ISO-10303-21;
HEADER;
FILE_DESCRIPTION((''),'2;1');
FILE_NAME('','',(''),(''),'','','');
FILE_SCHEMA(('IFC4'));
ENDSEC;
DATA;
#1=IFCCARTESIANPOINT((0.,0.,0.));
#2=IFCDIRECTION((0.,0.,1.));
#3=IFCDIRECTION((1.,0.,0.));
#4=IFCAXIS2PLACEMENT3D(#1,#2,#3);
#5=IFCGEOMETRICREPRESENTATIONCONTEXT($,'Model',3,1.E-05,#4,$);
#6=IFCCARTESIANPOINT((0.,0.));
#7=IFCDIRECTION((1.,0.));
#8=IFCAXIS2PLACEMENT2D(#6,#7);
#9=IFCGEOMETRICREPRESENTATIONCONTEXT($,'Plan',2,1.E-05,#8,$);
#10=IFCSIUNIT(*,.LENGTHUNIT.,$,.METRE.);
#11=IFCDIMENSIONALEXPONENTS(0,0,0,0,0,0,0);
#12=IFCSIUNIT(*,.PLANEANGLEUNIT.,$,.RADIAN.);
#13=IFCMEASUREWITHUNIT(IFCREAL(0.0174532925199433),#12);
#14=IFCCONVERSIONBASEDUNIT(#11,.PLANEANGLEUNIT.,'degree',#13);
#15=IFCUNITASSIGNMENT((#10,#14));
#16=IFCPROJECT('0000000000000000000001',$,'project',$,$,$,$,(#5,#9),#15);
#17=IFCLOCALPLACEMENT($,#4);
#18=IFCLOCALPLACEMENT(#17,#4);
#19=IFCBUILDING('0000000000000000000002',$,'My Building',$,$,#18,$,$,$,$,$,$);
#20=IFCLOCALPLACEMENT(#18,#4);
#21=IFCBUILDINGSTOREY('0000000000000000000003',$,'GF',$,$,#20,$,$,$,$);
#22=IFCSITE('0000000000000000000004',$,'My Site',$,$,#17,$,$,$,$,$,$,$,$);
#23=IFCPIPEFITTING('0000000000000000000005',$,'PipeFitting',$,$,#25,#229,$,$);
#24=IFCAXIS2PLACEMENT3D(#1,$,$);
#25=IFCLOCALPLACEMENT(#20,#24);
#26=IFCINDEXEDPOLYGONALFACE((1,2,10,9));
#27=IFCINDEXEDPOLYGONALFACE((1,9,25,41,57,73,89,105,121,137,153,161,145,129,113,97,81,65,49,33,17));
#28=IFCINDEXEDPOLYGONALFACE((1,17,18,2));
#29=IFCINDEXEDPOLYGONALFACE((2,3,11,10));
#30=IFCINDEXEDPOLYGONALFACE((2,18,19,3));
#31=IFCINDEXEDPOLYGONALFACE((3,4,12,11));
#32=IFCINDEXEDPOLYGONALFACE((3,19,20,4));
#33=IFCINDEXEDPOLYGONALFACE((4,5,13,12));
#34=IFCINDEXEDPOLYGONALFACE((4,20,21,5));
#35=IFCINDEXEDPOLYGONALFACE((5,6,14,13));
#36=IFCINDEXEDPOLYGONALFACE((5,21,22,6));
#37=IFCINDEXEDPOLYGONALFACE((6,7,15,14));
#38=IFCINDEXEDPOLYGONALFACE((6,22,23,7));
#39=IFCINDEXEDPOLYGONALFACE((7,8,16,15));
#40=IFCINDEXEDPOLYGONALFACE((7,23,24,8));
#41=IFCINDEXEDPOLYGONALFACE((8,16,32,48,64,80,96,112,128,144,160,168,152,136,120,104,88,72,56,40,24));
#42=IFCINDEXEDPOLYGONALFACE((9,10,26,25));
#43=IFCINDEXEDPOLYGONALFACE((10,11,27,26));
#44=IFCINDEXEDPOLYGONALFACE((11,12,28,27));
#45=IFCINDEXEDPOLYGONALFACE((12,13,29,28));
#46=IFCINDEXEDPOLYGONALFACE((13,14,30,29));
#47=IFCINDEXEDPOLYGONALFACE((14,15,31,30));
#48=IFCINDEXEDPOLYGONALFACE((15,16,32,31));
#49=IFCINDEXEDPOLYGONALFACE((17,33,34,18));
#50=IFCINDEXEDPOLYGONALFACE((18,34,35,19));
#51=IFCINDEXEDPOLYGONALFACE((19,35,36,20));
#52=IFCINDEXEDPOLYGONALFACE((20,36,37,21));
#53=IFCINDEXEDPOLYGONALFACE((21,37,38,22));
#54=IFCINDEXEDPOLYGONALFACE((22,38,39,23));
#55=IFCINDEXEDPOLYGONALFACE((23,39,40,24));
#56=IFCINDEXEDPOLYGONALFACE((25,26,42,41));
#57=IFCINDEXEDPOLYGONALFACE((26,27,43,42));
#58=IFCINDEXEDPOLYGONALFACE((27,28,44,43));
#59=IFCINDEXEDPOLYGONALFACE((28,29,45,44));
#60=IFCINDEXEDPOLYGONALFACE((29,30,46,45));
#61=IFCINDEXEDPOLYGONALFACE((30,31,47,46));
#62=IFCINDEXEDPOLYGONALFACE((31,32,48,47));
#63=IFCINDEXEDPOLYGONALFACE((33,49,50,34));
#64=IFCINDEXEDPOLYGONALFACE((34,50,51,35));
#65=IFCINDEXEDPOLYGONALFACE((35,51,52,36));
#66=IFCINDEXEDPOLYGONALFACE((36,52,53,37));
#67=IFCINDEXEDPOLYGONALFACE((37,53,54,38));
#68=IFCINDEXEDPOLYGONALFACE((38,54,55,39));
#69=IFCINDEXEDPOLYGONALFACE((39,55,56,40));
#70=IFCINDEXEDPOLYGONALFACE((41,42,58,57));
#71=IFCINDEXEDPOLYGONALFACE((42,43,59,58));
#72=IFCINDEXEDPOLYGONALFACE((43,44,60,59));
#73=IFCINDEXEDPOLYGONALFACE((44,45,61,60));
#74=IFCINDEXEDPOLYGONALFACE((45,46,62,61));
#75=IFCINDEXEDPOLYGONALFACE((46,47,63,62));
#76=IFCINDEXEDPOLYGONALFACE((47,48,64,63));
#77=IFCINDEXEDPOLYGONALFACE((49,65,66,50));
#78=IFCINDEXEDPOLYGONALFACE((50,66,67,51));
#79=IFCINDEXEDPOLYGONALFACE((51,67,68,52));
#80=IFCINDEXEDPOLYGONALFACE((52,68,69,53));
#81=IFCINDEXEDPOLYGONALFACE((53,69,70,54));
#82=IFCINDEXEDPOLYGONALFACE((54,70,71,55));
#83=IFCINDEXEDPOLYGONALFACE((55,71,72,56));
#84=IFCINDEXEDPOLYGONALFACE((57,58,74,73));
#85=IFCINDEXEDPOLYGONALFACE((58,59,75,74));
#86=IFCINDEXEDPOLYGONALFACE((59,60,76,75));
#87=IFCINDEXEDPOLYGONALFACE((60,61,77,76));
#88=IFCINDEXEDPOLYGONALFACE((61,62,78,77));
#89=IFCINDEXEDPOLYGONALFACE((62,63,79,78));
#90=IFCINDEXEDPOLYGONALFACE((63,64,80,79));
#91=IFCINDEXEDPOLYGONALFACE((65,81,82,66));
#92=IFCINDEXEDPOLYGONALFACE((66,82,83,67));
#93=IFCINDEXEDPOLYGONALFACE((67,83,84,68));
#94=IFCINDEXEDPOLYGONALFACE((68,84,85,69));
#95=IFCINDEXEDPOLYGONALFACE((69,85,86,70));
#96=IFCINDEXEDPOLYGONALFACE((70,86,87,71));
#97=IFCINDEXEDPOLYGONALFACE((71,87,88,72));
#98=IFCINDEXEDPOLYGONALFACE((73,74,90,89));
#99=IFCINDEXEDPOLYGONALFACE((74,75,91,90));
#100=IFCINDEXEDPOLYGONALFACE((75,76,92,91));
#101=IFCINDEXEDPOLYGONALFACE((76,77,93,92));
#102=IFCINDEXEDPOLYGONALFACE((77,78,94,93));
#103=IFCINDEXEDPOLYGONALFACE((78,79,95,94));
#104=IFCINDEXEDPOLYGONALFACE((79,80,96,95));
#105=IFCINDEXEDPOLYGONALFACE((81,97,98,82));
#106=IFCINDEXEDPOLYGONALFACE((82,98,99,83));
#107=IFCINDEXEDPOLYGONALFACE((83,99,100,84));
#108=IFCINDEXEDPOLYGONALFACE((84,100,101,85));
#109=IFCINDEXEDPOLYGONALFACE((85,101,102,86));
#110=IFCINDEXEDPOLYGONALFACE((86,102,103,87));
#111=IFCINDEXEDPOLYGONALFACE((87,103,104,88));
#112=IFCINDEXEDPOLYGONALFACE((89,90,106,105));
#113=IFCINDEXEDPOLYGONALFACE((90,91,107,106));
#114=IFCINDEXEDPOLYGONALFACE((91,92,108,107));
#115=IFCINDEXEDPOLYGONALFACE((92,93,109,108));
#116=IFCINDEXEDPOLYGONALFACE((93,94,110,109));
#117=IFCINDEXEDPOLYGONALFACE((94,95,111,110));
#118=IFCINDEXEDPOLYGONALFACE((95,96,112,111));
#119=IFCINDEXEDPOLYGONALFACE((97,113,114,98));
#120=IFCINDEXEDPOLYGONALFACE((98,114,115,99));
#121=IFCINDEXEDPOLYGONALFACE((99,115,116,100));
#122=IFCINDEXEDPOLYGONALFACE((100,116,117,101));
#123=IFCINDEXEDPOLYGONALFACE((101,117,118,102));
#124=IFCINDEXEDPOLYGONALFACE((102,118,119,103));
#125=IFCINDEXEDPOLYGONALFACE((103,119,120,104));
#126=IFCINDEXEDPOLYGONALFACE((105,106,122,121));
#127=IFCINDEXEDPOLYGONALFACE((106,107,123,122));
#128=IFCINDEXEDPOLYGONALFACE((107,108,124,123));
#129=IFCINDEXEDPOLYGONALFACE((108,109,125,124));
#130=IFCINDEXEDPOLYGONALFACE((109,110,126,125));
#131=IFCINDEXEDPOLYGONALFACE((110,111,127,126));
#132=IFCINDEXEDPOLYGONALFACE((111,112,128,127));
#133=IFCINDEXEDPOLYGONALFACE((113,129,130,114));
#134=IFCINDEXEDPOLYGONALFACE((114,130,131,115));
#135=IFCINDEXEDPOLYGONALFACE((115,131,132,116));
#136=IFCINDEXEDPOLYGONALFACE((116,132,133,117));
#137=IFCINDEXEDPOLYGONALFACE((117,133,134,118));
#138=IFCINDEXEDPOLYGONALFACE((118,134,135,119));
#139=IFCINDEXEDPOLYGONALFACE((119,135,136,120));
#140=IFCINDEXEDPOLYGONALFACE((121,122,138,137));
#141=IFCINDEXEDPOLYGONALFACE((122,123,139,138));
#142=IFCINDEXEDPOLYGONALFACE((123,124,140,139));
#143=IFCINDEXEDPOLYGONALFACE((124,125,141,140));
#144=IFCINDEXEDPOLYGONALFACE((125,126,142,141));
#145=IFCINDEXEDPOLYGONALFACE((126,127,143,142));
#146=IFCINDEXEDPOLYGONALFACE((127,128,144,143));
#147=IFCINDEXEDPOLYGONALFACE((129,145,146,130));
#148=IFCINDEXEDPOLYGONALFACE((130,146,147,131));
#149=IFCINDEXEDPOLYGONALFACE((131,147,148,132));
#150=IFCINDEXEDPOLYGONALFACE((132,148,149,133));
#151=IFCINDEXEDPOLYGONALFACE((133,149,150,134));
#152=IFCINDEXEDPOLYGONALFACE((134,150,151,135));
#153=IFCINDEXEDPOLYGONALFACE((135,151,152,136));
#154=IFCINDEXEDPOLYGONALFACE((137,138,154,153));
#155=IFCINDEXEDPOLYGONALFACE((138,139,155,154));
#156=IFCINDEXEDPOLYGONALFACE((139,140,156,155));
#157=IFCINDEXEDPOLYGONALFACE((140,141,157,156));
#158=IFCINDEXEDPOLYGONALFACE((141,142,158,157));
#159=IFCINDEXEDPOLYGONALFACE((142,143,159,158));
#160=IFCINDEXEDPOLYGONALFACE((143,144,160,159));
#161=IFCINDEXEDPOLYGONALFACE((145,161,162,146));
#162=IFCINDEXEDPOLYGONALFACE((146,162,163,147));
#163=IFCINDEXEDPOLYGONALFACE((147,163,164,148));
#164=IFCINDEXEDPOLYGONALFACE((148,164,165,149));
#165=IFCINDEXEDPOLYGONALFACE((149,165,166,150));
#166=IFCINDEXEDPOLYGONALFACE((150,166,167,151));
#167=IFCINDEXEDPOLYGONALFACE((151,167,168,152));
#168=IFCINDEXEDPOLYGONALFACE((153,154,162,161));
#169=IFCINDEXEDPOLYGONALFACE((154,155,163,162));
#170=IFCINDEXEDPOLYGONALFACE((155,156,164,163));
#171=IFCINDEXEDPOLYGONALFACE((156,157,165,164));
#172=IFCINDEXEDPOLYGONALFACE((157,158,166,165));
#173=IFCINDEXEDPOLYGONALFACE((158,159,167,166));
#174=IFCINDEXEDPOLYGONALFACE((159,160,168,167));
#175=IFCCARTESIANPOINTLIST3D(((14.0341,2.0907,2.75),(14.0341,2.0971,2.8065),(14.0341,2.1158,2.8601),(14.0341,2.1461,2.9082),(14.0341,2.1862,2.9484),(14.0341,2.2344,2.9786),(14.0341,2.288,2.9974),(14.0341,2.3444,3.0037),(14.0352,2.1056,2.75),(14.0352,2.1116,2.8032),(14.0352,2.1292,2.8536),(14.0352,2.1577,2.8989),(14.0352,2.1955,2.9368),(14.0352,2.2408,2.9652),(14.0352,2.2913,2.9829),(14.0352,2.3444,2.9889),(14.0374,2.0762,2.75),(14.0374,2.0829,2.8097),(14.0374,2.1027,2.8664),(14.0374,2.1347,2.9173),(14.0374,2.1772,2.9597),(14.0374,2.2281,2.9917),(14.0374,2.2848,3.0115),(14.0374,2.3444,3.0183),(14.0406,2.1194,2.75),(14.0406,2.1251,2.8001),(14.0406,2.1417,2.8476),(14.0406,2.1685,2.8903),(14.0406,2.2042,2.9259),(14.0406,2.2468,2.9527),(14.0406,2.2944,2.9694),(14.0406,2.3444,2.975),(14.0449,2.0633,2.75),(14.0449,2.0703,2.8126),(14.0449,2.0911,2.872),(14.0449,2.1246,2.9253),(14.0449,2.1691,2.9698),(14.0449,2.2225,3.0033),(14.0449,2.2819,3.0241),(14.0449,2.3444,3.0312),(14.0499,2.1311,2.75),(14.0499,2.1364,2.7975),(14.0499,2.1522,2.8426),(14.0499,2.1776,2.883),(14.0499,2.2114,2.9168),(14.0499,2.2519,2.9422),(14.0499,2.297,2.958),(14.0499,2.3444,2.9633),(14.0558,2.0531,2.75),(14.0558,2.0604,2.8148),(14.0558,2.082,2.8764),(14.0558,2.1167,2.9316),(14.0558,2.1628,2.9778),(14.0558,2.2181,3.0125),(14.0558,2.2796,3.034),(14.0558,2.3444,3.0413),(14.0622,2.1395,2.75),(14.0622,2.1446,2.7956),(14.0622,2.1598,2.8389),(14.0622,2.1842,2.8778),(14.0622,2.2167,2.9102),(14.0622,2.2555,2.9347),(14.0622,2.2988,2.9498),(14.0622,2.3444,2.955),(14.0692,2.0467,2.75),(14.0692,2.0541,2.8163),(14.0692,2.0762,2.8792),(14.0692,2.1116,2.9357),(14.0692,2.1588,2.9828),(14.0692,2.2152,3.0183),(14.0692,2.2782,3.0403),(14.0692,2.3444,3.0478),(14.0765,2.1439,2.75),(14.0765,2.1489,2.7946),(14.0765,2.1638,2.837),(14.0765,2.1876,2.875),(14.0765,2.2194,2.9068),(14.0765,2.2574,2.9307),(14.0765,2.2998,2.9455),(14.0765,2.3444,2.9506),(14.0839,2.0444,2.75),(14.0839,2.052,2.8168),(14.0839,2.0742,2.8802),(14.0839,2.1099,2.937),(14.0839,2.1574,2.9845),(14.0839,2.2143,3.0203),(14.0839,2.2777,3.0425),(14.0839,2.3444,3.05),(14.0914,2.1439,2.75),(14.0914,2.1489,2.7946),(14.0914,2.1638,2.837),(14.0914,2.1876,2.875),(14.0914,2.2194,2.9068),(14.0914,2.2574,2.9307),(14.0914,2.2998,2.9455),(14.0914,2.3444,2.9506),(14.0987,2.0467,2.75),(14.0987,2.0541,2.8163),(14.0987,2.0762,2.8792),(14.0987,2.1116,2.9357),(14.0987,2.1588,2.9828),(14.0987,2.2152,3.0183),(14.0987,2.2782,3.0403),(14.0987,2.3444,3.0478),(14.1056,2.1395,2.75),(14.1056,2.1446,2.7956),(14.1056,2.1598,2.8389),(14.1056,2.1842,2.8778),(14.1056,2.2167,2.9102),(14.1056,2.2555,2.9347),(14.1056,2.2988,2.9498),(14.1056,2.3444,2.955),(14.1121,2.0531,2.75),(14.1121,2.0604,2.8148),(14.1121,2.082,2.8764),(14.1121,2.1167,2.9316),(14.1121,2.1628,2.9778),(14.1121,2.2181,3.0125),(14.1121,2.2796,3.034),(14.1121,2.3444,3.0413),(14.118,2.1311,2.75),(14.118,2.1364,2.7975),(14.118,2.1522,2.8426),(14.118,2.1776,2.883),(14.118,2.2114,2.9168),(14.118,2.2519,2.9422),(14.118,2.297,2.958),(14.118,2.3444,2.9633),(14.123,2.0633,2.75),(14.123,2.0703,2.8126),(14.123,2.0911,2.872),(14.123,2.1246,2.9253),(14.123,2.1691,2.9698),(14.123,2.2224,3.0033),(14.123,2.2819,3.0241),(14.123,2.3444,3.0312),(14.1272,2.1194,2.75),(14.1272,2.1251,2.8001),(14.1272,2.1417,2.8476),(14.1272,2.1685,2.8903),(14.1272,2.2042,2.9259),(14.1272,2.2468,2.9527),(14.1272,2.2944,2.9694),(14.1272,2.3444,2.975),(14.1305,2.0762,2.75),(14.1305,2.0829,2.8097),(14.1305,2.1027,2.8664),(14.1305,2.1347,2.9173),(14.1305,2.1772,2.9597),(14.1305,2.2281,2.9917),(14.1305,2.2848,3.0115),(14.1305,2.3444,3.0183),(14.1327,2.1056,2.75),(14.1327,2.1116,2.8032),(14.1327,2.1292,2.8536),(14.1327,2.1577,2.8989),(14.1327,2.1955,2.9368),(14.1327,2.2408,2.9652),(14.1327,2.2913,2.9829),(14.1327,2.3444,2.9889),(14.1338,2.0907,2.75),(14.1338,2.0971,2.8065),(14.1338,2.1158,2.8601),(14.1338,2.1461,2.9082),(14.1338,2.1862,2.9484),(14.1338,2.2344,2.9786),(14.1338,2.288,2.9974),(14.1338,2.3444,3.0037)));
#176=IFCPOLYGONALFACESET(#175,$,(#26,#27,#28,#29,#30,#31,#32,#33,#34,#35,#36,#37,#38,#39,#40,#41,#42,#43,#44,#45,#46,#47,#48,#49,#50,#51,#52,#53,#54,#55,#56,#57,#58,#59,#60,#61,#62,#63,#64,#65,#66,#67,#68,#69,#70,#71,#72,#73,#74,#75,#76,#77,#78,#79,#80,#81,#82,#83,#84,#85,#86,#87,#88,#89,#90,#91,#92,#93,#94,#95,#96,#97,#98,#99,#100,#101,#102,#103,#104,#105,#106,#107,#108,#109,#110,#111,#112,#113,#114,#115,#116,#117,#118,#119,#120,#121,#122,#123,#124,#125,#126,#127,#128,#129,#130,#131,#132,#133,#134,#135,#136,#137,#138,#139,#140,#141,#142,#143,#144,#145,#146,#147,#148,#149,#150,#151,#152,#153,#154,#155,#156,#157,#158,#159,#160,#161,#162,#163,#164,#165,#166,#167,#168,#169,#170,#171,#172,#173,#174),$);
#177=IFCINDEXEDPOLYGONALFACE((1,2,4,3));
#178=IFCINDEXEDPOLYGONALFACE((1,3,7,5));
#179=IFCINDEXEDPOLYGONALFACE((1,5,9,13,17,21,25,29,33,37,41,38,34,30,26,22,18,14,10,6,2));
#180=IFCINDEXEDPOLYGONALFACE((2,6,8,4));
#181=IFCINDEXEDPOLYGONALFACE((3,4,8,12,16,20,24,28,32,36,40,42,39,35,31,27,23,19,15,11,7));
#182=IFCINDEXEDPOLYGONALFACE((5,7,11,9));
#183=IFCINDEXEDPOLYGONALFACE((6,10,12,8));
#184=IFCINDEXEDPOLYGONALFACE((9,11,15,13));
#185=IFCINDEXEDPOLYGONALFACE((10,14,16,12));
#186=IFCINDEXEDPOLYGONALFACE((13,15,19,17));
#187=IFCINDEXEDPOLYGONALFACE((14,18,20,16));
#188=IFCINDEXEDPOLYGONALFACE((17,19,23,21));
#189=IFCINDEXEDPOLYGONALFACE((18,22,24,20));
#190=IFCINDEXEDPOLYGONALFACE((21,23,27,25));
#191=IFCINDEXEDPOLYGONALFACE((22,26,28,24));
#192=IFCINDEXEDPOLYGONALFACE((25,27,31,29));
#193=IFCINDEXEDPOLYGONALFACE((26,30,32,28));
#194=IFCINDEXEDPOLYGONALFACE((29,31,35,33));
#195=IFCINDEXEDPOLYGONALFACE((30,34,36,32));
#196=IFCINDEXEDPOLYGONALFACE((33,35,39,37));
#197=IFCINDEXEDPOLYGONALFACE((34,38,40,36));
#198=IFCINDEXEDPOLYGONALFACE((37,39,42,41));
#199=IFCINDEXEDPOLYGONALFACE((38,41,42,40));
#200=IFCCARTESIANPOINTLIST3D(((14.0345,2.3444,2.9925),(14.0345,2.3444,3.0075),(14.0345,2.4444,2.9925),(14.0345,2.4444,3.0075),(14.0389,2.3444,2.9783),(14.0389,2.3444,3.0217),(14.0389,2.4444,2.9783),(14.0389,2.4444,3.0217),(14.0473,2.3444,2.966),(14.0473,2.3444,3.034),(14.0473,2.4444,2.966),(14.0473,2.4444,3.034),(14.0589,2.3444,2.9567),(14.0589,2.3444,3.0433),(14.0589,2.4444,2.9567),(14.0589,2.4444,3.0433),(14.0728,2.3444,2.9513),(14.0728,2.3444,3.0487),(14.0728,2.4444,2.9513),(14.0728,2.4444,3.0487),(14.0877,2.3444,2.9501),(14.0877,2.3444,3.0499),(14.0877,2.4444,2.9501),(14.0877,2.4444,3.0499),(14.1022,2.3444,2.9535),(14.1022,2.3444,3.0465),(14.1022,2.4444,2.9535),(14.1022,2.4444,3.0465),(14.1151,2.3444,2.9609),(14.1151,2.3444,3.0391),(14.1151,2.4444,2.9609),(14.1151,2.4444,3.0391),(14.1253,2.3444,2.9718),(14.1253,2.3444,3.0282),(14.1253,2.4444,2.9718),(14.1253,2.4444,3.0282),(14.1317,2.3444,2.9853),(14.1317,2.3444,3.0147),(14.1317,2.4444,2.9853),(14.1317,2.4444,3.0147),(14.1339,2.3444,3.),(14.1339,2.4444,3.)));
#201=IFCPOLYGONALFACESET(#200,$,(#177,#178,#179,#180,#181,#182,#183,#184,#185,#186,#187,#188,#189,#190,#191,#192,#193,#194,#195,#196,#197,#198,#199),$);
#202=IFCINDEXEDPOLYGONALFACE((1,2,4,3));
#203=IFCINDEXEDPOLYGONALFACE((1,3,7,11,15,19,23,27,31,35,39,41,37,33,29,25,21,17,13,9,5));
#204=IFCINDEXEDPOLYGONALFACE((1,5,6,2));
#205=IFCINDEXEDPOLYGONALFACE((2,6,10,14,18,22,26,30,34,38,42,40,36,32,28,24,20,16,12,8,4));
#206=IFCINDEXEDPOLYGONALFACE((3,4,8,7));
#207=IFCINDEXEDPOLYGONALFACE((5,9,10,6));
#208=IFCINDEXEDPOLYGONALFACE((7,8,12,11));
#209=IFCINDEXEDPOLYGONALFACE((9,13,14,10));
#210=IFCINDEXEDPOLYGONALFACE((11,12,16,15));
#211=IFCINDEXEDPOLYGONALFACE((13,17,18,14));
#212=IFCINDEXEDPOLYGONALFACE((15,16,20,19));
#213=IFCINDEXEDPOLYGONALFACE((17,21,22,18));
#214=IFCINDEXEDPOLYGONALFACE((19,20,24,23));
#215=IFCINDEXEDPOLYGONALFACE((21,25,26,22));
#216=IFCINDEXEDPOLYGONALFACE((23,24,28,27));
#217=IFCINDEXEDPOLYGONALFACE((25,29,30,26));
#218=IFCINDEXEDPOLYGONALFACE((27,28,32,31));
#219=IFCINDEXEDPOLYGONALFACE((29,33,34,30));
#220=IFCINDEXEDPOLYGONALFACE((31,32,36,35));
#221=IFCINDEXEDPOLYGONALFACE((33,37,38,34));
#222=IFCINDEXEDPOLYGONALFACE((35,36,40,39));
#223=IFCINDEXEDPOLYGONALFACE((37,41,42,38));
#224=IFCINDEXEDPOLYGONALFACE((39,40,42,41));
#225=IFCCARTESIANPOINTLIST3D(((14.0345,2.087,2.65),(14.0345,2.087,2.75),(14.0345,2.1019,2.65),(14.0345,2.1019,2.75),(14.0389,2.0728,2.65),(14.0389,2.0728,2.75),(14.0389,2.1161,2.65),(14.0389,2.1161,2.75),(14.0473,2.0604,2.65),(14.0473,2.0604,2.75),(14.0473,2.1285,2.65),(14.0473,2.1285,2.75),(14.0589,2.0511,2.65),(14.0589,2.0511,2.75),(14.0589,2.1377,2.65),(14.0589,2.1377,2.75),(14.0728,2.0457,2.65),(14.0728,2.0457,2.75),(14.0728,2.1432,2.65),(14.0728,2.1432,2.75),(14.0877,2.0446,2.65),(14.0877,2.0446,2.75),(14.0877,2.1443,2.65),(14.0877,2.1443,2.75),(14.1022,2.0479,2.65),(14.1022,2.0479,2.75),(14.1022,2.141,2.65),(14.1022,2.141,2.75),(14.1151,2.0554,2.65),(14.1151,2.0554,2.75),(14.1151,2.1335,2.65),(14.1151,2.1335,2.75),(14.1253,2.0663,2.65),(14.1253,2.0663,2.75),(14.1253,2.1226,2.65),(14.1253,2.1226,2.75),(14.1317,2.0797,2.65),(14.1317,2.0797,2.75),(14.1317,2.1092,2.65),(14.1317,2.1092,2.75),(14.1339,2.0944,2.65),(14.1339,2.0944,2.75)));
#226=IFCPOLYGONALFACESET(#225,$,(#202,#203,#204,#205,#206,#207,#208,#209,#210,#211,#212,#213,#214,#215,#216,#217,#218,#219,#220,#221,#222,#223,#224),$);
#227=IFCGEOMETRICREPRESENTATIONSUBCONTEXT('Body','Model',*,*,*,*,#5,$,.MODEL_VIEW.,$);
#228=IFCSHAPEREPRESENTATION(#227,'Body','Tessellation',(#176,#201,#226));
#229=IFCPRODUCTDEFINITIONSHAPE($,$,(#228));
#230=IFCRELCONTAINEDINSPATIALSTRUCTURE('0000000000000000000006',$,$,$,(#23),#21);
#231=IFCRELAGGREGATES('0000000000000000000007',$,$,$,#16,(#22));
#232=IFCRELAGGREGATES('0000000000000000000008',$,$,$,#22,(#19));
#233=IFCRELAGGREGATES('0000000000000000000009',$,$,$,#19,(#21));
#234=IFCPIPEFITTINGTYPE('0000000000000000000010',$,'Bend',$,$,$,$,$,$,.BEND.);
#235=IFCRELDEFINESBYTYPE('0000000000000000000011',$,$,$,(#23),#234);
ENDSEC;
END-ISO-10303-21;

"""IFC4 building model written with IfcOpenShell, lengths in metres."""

from ifc_helpers import new_model, entity, si_unit, converted_unit, frame, origin_with_axes, origin_2d_with_axis, place, context, subcontext, project, spatial, circle, extrude, source, transform, mapped, type_object, type_shapes, element, save


model = new_model("IFC4")

# Units and contexts
model_context = context("Model", 3, precision=1e-05, world=origin_with_axes())
plan_context = context("Plan", 2, precision=1e-05, world=origin_2d_with_axis())
body_context = subcontext(model_context, "Body", "Model", "MODEL_VIEW")
ifc_project = project(units=[si_unit("LENGTHUNIT", "METRE"), converted_unit("PLANEANGLEUNIT", "degree", entity("IfcReal", 0.0174532925199433), si_unit("PLANEANGLEUNIT", "RADIAN"), dimensions=[0, 0, 0, 0, 0, 0, 0])], contexts=[model_context, plan_context])

# Site, building, storey
site_placement = place(None, origin_with_axes())
site = spatial("IfcSite", under=ifc_project, at=site_placement, Name="My Site")
building_placement = place(site_placement, origin_with_axes())
building = spatial("IfcBuilding", under=site, at=building_placement, Name="My Building")
storey_placement = place(building_placement, origin_with_axes())
storey = spatial("IfcBuildingStorey", under=building, at=storey_placement, Name="GF")

# Pipe fitting
pipe_fitting_type = type_object("IfcPipeFittingType", Name="Bend", PredefinedType="BEND")
shared_shape = source(origin_with_axes(), body_context, "Body", "SolidModel", [
    entity("IfcSweptDiskSolid", entity("IfcIndexedPolyCurve", entity("IfcCartesianPointList3D", [[0.0, 0.0, 0.1], [0.0, -0.0732, 0.2768], [0.0, -0.25, 0.35]]), [entity("IfcArcIndex", [1, 2, 3])]), 0.05),
    extrude(circle(Radius=0.05), origin_with_axes(), (0.0, 0.0, 1.0), 0.1),
    extrude(circle(Radius=0.05), frame((0.0, -0.25, 0.35), z_axis=(0.0, -1.0, 0.0), x_axis=(1.0, 0.0, 0.0)), (0.0, 0.0, 1.0), 0.1),
])
type_shapes(pipe_fitting_type, [shared_shape])
for number, where, z_axis, x_axis, name in (
    (1, (14.0839, 2.4444, 3.0), (0.0, -1.0, 0.0), (1.0, 0.0, 0.0), "PipeFitting"),
):
    element("IfcPipeFitting", number, at=place(storey_placement, frame(where, z_axis=z_axis, x_axis=x_axis)), inside=storey, type_object=pipe_fitting_type, Name=name, context=body_context, shape_type="MappedRepresentation", body=[
        mapped(shared_shape, transform((0.0, 0.0, 0.0), x_axis=(1.0, 0.0, 0.0), y_axis=(0.0, 1.0, 0.0), z_axis=(0.0, 0.0, 1.0), scale=1.0)),
    ])

save(model, "model.ifc")
